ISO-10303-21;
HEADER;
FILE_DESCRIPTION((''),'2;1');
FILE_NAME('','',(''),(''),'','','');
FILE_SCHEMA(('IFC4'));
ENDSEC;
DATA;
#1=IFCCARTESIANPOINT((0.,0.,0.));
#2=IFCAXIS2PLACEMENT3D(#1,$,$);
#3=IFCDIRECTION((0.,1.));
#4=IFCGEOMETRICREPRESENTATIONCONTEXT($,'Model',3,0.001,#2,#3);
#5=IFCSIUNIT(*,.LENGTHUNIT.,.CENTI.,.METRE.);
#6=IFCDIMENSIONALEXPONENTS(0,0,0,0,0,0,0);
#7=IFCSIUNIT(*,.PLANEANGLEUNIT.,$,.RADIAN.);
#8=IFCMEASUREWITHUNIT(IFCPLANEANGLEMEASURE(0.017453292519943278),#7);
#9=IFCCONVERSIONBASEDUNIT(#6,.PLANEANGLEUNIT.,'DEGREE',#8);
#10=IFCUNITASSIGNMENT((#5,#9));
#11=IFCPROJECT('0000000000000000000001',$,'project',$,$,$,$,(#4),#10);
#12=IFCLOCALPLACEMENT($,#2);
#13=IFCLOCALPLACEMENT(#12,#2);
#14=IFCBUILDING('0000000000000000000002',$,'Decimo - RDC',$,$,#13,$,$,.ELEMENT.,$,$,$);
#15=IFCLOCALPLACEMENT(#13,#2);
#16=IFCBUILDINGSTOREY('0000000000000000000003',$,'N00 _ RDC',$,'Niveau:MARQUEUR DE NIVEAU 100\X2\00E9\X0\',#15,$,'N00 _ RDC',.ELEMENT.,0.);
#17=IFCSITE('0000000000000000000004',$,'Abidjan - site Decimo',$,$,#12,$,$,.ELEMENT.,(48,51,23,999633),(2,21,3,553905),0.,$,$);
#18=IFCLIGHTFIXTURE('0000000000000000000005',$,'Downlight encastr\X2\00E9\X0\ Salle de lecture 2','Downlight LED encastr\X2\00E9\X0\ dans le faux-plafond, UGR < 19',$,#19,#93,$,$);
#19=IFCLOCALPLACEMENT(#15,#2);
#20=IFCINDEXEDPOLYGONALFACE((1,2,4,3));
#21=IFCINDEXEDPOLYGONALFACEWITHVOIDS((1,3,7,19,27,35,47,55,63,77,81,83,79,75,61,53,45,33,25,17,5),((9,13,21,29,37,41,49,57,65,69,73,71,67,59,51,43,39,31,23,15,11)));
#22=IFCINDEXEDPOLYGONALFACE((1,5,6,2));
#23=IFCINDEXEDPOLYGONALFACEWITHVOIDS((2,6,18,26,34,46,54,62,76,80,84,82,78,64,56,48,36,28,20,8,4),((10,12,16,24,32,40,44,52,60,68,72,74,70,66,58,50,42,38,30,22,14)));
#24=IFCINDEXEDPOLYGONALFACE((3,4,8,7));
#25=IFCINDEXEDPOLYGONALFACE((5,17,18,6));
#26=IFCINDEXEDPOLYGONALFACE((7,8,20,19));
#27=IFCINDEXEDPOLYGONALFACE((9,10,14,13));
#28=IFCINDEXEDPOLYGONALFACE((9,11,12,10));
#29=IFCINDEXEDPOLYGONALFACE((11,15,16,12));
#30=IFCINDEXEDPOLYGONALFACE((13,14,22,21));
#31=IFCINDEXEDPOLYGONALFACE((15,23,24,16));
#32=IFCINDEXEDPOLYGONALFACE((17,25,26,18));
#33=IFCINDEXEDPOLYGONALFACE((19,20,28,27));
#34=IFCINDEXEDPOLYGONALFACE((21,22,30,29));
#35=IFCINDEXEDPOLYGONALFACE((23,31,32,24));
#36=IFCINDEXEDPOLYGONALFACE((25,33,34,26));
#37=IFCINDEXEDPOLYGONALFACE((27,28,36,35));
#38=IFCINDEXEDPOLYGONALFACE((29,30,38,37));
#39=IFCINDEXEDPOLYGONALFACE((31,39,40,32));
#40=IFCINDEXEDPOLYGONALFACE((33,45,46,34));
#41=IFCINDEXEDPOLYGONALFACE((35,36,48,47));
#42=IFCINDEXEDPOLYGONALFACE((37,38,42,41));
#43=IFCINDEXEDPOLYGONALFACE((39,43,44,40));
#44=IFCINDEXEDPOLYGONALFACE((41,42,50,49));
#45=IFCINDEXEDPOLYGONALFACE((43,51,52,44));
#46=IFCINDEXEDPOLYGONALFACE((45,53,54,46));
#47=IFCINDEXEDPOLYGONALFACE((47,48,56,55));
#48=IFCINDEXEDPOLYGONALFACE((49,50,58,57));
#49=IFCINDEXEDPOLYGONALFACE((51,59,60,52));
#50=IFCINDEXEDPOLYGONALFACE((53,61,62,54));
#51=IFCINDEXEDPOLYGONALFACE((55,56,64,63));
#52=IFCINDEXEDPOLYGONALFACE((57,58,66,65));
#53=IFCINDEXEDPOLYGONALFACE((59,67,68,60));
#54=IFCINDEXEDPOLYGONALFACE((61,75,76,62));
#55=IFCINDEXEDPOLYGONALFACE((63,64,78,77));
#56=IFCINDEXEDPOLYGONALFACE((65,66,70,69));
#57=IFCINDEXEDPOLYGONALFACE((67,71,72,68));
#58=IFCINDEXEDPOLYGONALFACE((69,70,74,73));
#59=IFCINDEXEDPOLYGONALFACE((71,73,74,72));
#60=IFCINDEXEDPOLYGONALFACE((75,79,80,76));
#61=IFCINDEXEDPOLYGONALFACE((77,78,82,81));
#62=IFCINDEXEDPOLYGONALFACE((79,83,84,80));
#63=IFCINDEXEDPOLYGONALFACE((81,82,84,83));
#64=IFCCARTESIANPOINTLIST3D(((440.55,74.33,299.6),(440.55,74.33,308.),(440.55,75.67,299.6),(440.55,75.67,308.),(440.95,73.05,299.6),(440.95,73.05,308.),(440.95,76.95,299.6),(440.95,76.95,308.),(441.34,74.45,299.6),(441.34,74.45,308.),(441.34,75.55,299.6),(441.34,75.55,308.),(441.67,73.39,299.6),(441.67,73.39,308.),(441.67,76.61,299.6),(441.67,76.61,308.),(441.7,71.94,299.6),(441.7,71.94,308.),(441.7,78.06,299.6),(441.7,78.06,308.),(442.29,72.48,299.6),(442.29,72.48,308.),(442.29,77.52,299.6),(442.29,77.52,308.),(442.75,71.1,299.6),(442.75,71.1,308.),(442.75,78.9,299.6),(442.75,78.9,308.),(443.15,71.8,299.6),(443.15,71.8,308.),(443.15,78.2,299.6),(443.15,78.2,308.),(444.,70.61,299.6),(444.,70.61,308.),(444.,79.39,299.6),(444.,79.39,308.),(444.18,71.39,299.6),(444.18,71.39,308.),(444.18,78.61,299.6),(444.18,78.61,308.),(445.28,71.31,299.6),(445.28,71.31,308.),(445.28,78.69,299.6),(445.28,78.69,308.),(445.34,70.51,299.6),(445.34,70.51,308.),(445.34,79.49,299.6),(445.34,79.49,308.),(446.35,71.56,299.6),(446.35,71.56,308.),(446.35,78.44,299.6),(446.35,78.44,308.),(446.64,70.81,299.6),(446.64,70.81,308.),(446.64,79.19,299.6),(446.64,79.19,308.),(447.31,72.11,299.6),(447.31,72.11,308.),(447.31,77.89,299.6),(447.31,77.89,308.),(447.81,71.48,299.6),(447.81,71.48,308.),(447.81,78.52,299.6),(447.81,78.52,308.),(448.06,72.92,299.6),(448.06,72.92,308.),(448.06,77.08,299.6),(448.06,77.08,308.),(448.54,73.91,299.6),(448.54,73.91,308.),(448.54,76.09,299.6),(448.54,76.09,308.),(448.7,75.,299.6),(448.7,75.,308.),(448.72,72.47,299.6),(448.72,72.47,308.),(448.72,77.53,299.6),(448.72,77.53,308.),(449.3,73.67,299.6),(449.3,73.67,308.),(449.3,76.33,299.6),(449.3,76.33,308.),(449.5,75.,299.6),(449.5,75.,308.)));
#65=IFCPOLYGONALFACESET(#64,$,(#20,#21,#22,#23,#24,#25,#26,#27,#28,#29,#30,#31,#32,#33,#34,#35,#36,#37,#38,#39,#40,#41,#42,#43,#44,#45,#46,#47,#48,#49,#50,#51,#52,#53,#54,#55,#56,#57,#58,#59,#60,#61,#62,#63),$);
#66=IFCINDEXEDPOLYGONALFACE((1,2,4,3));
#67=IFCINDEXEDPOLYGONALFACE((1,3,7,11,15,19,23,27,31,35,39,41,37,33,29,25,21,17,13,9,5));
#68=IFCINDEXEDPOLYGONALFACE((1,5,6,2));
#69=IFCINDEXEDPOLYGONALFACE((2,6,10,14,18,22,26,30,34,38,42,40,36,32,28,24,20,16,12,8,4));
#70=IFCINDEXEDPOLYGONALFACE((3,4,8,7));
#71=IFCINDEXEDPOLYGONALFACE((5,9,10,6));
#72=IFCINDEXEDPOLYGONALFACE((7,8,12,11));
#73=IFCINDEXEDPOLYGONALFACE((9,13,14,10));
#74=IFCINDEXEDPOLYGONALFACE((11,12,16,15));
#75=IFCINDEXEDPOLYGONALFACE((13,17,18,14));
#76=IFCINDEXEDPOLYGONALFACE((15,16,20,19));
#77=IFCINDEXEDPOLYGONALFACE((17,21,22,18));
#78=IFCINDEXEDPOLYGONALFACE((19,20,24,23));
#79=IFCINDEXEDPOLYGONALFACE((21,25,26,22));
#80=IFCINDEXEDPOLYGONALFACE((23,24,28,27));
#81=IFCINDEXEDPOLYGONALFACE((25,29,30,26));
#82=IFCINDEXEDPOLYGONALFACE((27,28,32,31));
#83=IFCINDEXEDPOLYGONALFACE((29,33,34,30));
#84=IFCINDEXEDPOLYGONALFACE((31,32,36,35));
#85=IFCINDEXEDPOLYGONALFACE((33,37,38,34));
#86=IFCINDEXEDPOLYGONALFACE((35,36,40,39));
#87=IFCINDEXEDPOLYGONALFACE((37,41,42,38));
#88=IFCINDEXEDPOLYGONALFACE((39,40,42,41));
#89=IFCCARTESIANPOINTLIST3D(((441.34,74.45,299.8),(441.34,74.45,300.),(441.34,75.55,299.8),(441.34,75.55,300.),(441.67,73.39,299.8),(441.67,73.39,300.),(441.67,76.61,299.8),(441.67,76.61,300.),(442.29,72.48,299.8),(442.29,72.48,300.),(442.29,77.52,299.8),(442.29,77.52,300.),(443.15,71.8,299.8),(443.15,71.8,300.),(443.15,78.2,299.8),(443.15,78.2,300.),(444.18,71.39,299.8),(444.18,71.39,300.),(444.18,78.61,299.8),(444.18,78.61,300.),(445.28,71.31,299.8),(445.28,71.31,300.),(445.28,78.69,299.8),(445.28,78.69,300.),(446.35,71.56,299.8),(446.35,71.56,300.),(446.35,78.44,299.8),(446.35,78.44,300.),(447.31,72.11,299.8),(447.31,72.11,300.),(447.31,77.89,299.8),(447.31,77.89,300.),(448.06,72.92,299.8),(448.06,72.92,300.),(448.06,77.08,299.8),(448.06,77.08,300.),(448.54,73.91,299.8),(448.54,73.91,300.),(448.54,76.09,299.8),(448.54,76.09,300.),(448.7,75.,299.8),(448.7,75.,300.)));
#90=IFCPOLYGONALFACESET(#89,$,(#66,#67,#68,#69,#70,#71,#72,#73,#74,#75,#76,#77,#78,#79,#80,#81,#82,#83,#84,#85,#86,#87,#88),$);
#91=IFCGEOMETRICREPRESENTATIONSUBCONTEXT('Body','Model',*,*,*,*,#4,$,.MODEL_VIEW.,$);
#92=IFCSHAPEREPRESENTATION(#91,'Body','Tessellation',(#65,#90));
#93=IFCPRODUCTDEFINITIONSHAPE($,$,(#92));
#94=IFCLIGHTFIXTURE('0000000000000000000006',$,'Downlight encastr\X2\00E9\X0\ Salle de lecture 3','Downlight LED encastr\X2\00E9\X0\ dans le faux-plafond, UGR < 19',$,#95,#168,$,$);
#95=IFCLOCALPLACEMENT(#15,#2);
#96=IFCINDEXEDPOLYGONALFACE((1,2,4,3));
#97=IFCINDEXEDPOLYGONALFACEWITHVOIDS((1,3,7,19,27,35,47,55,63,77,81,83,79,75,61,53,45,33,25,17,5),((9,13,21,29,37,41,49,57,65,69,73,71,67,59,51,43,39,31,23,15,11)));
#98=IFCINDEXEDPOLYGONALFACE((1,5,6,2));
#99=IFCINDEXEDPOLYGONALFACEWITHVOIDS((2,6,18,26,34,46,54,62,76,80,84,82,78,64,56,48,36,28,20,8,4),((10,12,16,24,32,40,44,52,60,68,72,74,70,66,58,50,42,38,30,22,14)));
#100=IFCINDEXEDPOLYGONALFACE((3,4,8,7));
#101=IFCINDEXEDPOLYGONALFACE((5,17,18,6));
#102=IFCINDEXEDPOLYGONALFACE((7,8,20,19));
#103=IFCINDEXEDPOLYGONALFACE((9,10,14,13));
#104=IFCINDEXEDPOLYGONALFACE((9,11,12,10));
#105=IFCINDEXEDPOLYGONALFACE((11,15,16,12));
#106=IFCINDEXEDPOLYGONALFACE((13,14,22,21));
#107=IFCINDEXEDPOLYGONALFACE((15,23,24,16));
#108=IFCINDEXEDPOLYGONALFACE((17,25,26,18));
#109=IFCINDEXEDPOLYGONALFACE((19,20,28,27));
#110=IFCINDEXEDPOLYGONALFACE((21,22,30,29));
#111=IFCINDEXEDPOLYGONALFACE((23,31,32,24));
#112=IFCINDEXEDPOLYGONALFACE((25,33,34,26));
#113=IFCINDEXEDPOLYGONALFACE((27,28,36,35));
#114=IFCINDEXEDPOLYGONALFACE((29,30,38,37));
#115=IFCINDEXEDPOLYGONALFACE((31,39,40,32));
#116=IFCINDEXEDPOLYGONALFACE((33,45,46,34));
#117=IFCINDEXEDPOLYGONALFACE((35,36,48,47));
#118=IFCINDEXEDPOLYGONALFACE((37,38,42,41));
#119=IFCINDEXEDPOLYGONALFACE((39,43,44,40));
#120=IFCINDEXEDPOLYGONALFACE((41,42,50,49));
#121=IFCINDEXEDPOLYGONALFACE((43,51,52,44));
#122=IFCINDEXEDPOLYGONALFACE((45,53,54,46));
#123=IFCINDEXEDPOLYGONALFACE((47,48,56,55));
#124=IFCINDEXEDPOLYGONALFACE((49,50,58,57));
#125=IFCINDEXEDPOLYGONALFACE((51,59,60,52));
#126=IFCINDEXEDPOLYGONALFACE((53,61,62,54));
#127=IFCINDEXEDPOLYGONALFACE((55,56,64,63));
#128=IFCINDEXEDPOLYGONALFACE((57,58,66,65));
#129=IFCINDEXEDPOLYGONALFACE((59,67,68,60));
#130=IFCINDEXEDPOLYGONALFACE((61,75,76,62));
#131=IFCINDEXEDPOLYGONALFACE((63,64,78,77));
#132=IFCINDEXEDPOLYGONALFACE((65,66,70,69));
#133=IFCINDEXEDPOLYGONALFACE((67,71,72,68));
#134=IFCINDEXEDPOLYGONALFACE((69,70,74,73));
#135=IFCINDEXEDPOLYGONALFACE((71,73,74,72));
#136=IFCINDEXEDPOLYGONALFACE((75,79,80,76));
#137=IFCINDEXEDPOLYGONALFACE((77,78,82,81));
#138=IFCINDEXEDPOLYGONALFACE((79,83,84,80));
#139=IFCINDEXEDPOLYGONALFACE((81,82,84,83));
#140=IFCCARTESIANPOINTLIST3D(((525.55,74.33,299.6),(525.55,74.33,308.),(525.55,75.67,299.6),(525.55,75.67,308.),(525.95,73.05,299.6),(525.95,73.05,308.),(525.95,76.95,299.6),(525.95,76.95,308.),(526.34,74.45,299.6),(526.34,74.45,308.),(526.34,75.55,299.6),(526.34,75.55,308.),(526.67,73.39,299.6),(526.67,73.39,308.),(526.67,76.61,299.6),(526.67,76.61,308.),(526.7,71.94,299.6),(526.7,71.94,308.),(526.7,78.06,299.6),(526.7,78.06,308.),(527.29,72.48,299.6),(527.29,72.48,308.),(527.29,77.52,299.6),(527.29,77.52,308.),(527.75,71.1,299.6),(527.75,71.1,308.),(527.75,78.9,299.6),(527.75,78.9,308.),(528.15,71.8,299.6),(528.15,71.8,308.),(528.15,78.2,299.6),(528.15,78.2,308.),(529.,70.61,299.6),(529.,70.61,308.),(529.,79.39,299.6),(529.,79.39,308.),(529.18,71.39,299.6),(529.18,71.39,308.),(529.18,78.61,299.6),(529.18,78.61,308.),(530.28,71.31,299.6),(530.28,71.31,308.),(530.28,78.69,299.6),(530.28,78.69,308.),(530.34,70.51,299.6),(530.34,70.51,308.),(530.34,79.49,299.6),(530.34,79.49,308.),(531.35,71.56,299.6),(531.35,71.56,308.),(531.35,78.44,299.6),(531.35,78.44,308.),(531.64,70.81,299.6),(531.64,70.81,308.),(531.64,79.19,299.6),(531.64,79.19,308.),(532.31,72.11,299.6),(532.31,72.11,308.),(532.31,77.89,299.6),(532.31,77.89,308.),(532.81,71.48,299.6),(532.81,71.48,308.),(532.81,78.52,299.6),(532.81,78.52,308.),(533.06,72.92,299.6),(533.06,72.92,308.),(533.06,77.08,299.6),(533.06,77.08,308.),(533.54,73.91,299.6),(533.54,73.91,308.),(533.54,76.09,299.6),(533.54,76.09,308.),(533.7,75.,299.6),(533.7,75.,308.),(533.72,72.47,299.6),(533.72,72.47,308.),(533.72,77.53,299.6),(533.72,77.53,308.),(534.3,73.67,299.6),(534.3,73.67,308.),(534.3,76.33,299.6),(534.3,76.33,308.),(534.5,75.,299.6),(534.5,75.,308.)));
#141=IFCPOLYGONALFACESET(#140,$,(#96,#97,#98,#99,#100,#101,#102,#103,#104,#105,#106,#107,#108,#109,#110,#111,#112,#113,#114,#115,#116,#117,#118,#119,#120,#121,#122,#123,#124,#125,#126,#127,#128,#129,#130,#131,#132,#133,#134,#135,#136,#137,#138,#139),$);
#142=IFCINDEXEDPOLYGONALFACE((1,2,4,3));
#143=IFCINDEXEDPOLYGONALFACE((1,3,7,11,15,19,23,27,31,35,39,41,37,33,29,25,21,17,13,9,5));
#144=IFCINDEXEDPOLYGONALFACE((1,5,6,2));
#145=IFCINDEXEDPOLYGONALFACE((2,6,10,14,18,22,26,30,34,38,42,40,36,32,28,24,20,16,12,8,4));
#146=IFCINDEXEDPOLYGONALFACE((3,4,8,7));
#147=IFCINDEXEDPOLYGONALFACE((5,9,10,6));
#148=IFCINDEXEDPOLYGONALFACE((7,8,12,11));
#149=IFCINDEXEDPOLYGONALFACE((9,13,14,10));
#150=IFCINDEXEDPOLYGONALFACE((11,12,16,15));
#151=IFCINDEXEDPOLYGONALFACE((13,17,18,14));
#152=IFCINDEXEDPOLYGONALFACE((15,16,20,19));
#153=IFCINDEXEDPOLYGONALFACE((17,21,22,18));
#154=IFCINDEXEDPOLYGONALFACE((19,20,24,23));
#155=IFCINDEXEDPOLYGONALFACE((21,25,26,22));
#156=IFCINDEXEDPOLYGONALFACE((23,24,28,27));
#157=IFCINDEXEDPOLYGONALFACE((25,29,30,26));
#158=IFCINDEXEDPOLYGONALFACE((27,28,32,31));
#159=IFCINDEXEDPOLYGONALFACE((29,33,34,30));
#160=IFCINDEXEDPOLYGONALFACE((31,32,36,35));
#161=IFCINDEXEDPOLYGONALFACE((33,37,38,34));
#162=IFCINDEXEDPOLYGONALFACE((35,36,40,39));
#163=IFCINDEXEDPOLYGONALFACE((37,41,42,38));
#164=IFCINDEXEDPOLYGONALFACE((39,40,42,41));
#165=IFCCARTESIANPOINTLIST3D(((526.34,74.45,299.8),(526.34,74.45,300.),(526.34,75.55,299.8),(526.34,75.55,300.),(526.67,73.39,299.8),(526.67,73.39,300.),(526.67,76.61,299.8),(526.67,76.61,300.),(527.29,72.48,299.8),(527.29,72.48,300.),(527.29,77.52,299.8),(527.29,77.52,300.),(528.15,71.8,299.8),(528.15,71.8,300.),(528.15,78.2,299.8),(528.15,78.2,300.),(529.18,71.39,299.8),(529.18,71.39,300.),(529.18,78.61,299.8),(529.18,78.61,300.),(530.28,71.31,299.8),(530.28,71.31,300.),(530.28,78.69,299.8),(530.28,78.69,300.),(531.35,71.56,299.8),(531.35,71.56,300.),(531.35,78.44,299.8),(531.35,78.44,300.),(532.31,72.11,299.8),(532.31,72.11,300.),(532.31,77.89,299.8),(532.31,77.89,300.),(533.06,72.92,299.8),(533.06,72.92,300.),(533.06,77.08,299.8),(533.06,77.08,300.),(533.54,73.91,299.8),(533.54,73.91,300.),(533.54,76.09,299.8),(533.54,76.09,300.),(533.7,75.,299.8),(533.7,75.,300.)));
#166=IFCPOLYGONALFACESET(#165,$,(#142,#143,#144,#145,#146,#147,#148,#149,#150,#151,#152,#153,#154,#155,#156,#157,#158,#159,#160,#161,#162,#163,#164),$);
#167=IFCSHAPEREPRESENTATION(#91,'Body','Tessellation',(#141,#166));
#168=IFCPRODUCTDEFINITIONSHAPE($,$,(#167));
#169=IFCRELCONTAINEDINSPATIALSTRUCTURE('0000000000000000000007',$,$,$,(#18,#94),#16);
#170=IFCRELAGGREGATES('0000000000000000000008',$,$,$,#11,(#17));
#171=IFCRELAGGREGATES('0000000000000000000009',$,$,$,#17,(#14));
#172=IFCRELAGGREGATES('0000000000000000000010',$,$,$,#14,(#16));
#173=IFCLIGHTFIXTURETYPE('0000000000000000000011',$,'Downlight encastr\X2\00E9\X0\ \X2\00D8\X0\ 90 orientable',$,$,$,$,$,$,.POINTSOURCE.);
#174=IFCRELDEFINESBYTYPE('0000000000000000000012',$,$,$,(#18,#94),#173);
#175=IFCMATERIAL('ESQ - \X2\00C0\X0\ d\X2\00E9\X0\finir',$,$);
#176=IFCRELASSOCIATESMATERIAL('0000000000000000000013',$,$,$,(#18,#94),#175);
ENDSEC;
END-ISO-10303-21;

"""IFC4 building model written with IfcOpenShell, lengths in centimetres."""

from ifc_helpers import new_model, entity, si_unit, converted_unit, direction, frame, frame_2d, origin, origin_with_axes, place, context, subcontext, project, spatial, circle, hollow_circle, extrude, material, type_object, element, save


model = new_model("IFC4")

# Units and contexts
model_context = context("Model", 3, precision=0.001, world=origin(), true_north=direction((0.0, 1.0)))
body_context = subcontext(model_context, "Body", "Model", "MODEL_VIEW")
ifc_project = project(units=[si_unit("LENGTHUNIT", "METRE", prefix="CENTI"), converted_unit("PLANEANGLEUNIT", "DEGREE", entity("IfcPlaneAngleMeasure", 0.017453292519943278), si_unit("PLANEANGLEUNIT", "RADIAN"), dimensions=[0, 0, 0, 0, 0, 0, 0])], contexts=[model_context])

# Site, building, storey
site_placement = place(None, origin())
site = spatial("IfcSite", under=ifc_project, at=site_placement, Name="Abidjan - site Decimo", CompositionType="ELEMENT", RefLatitude=(48, 51, 23, 999633), RefLongitude=(2, 21, 3, 553905), RefElevation=0.0)
building_placement = place(site_placement, origin())
building = spatial("IfcBuilding", under=site, at=building_placement, Name="Decimo - RDC", CompositionType="ELEMENT")
storey_placement = place(building_placement, origin())
storey = spatial("IfcBuildingStorey", under=building, at=storey_placement, Name="N00 _ RDC", ObjectType="Niveau:MARQUEUR DE NIVEAU 100é", LongName="N00 _ RDC", CompositionType="ELEMENT", Elevation=0.0)

# Light fixtures
ifc_material_1 = material(Name="ESQ - À définir")
light_fixture_type_1 = type_object("IfcLightFixtureType", Name="Downlight encastré Ø 90 orientable", PredefinedType="POINTSOURCE")
light_fixture_1_placement = place(storey_placement, origin_with_axes())
element("IfcLightFixture", 1, at=light_fixture_1_placement, inside=storey, type_object=light_fixture_type_1, material=ifc_material_1, Name="Downlight encastré Salle de lecture 2", Description="Downlight LED encastré dans le faux-plafond, UGR < 19", context=body_context, shape_type="SweptSolid", body=[
    extrude(hollow_circle(Radius=4.5, WallThickness=0.8, at=frame_2d((445.0, 75.0))), frame((0.0, 0.0, 299.6)), (0.0, 0.0, 1.0), 8.4),
    extrude(circle(Radius=3.7, at=frame_2d((445.0, 75.0))), frame((0.0, 0.0, 299.8)), (0.0, 0.0, 1.0), 0.2),
])
light_fixture_2_placement = place(storey_placement, origin_with_axes())
element("IfcLightFixture", 2, at=light_fixture_2_placement, inside=storey, type_object=light_fixture_type_1, material=ifc_material_1, Name="Downlight encastré Salle de lecture 3", Description="Downlight LED encastré dans le faux-plafond, UGR < 19", context=body_context, shape_type="SweptSolid", body=[
    extrude(hollow_circle(Radius=4.5, WallThickness=0.8, at=frame_2d((530.0, 75.0))), frame((0.0, 0.0, 299.6)), (0.0, 0.0, 1.0), 8.4),
    extrude(circle(Radius=3.7, at=frame_2d((530.0, 75.0))), frame((0.0, 0.0, 299.8)), (0.0, 0.0, 1.0), 0.2),
])

save(model, "model.ifc")
